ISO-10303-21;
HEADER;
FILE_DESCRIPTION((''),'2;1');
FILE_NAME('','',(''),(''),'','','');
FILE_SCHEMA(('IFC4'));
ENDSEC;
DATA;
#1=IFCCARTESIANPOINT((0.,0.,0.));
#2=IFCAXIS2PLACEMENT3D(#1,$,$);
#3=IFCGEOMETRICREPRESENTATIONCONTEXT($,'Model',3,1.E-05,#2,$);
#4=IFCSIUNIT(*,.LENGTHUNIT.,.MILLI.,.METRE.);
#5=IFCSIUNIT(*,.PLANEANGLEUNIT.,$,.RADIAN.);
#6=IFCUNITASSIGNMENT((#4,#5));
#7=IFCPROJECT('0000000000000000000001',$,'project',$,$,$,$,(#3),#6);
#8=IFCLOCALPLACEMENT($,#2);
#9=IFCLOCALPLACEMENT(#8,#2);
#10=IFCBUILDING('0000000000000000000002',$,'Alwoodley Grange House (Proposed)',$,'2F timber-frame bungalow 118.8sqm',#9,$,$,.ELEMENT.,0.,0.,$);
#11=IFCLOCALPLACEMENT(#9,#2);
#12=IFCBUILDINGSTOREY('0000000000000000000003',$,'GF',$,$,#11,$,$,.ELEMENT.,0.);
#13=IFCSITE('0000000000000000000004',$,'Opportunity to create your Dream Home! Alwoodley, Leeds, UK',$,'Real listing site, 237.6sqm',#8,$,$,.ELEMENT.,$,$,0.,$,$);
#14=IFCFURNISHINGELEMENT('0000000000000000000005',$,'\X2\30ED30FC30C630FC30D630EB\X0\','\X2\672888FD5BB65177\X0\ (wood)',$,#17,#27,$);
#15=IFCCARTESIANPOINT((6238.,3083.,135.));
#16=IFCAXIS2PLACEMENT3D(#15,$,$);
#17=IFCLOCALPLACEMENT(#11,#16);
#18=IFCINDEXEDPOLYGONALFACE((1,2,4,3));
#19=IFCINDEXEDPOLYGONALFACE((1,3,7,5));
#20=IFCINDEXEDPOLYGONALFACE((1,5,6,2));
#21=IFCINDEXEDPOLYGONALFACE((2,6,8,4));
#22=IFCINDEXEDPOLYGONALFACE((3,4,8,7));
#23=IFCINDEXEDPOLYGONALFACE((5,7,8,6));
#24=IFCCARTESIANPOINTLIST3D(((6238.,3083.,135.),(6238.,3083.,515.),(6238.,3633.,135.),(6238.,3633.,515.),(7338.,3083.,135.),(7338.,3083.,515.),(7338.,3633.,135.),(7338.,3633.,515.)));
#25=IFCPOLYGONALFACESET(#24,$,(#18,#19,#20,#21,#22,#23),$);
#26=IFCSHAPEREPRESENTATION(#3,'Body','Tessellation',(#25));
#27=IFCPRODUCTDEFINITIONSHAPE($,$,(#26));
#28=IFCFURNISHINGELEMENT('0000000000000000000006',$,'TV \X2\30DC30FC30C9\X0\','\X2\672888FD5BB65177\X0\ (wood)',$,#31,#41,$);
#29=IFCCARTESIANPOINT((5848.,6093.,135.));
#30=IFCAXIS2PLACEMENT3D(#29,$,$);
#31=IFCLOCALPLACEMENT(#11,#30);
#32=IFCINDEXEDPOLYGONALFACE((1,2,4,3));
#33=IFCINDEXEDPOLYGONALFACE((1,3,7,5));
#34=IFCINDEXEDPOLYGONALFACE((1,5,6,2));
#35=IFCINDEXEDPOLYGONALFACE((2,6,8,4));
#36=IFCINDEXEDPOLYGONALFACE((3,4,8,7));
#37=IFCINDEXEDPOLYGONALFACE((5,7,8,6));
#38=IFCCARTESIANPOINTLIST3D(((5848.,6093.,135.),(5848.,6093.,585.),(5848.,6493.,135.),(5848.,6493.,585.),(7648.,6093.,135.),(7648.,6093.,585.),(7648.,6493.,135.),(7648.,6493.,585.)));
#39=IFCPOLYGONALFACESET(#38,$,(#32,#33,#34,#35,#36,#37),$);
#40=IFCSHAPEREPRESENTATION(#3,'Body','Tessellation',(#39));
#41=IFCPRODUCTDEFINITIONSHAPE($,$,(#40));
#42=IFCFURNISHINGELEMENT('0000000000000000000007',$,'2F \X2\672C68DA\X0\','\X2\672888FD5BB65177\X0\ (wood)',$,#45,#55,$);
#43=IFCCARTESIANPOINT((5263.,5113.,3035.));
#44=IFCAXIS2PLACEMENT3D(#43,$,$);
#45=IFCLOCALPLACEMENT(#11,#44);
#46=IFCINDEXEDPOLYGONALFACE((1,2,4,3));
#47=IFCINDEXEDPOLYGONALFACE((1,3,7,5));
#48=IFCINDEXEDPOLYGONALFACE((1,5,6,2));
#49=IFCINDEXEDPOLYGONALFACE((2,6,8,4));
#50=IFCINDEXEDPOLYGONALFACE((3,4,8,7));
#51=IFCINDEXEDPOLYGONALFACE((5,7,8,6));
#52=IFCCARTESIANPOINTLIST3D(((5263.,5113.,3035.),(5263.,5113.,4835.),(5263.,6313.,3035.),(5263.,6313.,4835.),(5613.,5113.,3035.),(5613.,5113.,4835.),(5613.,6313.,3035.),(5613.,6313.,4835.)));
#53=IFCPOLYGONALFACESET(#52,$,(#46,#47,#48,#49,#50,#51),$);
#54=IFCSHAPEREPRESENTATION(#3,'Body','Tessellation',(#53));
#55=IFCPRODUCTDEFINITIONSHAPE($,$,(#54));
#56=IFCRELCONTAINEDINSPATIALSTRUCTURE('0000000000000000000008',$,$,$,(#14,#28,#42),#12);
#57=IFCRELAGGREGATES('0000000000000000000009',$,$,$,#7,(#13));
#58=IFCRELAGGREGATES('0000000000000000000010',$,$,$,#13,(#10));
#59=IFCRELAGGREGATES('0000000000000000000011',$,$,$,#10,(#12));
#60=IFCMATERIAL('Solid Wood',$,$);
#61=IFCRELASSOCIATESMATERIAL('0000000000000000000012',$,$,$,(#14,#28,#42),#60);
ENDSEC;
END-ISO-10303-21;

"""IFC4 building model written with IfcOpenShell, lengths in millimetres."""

from ifc_helpers import new_model, si_unit, frame, frame_2d, origin, place, context, project, spatial, rectangle, extrude, material, element, save


model = new_model("IFC4")

# Units and contexts
model_context = context("Model", 3, precision=1e-05, world=origin())
ifc_project = project(units=[si_unit("LENGTHUNIT", "METRE", prefix="MILLI"), si_unit("PLANEANGLEUNIT", "RADIAN")], contexts=[model_context])

# Site, building, storey
site_placement = place(None, origin())
site = spatial("IfcSite", under=ifc_project, at=site_placement, Name="Opportunity to create your Dream Home! Alwoodley, Leeds, UK", ObjectType="Real listing site, 237.6sqm", CompositionType="ELEMENT", RefElevation=0.0)
building_placement = place(site_placement, origin())
building = spatial("IfcBuilding", under=site, at=building_placement, Name="Alwoodley Grange House (Proposed)", ObjectType="2F timber-frame bungalow 118.8sqm", CompositionType="ELEMENT", ElevationOfRefHeight=0.0, ElevationOfTerrain=0.0)
storey_placement = place(building_placement, origin())
storey = spatial("IfcBuildingStorey", under=building, at=storey_placement, Name="GF", CompositionType="ELEMENT", Elevation=0.0)

# Shared definitions
ifc_material_1 = material(Name="Solid Wood")

# Furnishing elements
furnishing_1_placement = place(storey_placement, frame((6238.0, 3083.0, 135.0)))
element("IfcFurnishingElement", 1, at=furnishing_1_placement, inside=storey, material=ifc_material_1, Name="ローテーブル", Description="木製家具 (wood)", context=model_context, shape_type="SweptSolid", body=[
    extrude(rectangle(XDim=1100.0, YDim=550.0, at=frame_2d((550.0, 275.0))), frame((6238.0, 3083.0, 135.0)), (0.0, 0.0, 1.0), 380.0),
])
furnishing_2_placement = place(storey_placement, frame((5848.0, 6093.0, 135.0)))
element("IfcFurnishingElement", 2, at=furnishing_2_placement, inside=storey, material=ifc_material_1, Name="TV ボード", Description="木製家具 (wood)", context=model_context, shape_type="SweptSolid", body=[
    extrude(rectangle(XDim=1800.0, YDim=400.0, at=frame_2d((900.0, 200.0))), frame((5848.0, 6093.0, 135.0)), (0.0, 0.0, 1.0), 450.0),
])
furnishing_3_placement = place(storey_placement, frame((5263.0, 5113.0, 3035.0)))
element("IfcFurnishingElement", 3, at=furnishing_3_placement, inside=storey, material=ifc_material_1, Name="2F 本棚", Description="木製家具 (wood)", context=model_context, shape_type="SweptSolid", body=[
    extrude(rectangle(XDim=350.0, YDim=1200.0, at=frame_2d((175.0, 600.0))), frame((5263.0, 5113.0, 3035.0)), (0.0, 0.0, 1.0), 1800.0),
])

save(model, "model.ifc")
